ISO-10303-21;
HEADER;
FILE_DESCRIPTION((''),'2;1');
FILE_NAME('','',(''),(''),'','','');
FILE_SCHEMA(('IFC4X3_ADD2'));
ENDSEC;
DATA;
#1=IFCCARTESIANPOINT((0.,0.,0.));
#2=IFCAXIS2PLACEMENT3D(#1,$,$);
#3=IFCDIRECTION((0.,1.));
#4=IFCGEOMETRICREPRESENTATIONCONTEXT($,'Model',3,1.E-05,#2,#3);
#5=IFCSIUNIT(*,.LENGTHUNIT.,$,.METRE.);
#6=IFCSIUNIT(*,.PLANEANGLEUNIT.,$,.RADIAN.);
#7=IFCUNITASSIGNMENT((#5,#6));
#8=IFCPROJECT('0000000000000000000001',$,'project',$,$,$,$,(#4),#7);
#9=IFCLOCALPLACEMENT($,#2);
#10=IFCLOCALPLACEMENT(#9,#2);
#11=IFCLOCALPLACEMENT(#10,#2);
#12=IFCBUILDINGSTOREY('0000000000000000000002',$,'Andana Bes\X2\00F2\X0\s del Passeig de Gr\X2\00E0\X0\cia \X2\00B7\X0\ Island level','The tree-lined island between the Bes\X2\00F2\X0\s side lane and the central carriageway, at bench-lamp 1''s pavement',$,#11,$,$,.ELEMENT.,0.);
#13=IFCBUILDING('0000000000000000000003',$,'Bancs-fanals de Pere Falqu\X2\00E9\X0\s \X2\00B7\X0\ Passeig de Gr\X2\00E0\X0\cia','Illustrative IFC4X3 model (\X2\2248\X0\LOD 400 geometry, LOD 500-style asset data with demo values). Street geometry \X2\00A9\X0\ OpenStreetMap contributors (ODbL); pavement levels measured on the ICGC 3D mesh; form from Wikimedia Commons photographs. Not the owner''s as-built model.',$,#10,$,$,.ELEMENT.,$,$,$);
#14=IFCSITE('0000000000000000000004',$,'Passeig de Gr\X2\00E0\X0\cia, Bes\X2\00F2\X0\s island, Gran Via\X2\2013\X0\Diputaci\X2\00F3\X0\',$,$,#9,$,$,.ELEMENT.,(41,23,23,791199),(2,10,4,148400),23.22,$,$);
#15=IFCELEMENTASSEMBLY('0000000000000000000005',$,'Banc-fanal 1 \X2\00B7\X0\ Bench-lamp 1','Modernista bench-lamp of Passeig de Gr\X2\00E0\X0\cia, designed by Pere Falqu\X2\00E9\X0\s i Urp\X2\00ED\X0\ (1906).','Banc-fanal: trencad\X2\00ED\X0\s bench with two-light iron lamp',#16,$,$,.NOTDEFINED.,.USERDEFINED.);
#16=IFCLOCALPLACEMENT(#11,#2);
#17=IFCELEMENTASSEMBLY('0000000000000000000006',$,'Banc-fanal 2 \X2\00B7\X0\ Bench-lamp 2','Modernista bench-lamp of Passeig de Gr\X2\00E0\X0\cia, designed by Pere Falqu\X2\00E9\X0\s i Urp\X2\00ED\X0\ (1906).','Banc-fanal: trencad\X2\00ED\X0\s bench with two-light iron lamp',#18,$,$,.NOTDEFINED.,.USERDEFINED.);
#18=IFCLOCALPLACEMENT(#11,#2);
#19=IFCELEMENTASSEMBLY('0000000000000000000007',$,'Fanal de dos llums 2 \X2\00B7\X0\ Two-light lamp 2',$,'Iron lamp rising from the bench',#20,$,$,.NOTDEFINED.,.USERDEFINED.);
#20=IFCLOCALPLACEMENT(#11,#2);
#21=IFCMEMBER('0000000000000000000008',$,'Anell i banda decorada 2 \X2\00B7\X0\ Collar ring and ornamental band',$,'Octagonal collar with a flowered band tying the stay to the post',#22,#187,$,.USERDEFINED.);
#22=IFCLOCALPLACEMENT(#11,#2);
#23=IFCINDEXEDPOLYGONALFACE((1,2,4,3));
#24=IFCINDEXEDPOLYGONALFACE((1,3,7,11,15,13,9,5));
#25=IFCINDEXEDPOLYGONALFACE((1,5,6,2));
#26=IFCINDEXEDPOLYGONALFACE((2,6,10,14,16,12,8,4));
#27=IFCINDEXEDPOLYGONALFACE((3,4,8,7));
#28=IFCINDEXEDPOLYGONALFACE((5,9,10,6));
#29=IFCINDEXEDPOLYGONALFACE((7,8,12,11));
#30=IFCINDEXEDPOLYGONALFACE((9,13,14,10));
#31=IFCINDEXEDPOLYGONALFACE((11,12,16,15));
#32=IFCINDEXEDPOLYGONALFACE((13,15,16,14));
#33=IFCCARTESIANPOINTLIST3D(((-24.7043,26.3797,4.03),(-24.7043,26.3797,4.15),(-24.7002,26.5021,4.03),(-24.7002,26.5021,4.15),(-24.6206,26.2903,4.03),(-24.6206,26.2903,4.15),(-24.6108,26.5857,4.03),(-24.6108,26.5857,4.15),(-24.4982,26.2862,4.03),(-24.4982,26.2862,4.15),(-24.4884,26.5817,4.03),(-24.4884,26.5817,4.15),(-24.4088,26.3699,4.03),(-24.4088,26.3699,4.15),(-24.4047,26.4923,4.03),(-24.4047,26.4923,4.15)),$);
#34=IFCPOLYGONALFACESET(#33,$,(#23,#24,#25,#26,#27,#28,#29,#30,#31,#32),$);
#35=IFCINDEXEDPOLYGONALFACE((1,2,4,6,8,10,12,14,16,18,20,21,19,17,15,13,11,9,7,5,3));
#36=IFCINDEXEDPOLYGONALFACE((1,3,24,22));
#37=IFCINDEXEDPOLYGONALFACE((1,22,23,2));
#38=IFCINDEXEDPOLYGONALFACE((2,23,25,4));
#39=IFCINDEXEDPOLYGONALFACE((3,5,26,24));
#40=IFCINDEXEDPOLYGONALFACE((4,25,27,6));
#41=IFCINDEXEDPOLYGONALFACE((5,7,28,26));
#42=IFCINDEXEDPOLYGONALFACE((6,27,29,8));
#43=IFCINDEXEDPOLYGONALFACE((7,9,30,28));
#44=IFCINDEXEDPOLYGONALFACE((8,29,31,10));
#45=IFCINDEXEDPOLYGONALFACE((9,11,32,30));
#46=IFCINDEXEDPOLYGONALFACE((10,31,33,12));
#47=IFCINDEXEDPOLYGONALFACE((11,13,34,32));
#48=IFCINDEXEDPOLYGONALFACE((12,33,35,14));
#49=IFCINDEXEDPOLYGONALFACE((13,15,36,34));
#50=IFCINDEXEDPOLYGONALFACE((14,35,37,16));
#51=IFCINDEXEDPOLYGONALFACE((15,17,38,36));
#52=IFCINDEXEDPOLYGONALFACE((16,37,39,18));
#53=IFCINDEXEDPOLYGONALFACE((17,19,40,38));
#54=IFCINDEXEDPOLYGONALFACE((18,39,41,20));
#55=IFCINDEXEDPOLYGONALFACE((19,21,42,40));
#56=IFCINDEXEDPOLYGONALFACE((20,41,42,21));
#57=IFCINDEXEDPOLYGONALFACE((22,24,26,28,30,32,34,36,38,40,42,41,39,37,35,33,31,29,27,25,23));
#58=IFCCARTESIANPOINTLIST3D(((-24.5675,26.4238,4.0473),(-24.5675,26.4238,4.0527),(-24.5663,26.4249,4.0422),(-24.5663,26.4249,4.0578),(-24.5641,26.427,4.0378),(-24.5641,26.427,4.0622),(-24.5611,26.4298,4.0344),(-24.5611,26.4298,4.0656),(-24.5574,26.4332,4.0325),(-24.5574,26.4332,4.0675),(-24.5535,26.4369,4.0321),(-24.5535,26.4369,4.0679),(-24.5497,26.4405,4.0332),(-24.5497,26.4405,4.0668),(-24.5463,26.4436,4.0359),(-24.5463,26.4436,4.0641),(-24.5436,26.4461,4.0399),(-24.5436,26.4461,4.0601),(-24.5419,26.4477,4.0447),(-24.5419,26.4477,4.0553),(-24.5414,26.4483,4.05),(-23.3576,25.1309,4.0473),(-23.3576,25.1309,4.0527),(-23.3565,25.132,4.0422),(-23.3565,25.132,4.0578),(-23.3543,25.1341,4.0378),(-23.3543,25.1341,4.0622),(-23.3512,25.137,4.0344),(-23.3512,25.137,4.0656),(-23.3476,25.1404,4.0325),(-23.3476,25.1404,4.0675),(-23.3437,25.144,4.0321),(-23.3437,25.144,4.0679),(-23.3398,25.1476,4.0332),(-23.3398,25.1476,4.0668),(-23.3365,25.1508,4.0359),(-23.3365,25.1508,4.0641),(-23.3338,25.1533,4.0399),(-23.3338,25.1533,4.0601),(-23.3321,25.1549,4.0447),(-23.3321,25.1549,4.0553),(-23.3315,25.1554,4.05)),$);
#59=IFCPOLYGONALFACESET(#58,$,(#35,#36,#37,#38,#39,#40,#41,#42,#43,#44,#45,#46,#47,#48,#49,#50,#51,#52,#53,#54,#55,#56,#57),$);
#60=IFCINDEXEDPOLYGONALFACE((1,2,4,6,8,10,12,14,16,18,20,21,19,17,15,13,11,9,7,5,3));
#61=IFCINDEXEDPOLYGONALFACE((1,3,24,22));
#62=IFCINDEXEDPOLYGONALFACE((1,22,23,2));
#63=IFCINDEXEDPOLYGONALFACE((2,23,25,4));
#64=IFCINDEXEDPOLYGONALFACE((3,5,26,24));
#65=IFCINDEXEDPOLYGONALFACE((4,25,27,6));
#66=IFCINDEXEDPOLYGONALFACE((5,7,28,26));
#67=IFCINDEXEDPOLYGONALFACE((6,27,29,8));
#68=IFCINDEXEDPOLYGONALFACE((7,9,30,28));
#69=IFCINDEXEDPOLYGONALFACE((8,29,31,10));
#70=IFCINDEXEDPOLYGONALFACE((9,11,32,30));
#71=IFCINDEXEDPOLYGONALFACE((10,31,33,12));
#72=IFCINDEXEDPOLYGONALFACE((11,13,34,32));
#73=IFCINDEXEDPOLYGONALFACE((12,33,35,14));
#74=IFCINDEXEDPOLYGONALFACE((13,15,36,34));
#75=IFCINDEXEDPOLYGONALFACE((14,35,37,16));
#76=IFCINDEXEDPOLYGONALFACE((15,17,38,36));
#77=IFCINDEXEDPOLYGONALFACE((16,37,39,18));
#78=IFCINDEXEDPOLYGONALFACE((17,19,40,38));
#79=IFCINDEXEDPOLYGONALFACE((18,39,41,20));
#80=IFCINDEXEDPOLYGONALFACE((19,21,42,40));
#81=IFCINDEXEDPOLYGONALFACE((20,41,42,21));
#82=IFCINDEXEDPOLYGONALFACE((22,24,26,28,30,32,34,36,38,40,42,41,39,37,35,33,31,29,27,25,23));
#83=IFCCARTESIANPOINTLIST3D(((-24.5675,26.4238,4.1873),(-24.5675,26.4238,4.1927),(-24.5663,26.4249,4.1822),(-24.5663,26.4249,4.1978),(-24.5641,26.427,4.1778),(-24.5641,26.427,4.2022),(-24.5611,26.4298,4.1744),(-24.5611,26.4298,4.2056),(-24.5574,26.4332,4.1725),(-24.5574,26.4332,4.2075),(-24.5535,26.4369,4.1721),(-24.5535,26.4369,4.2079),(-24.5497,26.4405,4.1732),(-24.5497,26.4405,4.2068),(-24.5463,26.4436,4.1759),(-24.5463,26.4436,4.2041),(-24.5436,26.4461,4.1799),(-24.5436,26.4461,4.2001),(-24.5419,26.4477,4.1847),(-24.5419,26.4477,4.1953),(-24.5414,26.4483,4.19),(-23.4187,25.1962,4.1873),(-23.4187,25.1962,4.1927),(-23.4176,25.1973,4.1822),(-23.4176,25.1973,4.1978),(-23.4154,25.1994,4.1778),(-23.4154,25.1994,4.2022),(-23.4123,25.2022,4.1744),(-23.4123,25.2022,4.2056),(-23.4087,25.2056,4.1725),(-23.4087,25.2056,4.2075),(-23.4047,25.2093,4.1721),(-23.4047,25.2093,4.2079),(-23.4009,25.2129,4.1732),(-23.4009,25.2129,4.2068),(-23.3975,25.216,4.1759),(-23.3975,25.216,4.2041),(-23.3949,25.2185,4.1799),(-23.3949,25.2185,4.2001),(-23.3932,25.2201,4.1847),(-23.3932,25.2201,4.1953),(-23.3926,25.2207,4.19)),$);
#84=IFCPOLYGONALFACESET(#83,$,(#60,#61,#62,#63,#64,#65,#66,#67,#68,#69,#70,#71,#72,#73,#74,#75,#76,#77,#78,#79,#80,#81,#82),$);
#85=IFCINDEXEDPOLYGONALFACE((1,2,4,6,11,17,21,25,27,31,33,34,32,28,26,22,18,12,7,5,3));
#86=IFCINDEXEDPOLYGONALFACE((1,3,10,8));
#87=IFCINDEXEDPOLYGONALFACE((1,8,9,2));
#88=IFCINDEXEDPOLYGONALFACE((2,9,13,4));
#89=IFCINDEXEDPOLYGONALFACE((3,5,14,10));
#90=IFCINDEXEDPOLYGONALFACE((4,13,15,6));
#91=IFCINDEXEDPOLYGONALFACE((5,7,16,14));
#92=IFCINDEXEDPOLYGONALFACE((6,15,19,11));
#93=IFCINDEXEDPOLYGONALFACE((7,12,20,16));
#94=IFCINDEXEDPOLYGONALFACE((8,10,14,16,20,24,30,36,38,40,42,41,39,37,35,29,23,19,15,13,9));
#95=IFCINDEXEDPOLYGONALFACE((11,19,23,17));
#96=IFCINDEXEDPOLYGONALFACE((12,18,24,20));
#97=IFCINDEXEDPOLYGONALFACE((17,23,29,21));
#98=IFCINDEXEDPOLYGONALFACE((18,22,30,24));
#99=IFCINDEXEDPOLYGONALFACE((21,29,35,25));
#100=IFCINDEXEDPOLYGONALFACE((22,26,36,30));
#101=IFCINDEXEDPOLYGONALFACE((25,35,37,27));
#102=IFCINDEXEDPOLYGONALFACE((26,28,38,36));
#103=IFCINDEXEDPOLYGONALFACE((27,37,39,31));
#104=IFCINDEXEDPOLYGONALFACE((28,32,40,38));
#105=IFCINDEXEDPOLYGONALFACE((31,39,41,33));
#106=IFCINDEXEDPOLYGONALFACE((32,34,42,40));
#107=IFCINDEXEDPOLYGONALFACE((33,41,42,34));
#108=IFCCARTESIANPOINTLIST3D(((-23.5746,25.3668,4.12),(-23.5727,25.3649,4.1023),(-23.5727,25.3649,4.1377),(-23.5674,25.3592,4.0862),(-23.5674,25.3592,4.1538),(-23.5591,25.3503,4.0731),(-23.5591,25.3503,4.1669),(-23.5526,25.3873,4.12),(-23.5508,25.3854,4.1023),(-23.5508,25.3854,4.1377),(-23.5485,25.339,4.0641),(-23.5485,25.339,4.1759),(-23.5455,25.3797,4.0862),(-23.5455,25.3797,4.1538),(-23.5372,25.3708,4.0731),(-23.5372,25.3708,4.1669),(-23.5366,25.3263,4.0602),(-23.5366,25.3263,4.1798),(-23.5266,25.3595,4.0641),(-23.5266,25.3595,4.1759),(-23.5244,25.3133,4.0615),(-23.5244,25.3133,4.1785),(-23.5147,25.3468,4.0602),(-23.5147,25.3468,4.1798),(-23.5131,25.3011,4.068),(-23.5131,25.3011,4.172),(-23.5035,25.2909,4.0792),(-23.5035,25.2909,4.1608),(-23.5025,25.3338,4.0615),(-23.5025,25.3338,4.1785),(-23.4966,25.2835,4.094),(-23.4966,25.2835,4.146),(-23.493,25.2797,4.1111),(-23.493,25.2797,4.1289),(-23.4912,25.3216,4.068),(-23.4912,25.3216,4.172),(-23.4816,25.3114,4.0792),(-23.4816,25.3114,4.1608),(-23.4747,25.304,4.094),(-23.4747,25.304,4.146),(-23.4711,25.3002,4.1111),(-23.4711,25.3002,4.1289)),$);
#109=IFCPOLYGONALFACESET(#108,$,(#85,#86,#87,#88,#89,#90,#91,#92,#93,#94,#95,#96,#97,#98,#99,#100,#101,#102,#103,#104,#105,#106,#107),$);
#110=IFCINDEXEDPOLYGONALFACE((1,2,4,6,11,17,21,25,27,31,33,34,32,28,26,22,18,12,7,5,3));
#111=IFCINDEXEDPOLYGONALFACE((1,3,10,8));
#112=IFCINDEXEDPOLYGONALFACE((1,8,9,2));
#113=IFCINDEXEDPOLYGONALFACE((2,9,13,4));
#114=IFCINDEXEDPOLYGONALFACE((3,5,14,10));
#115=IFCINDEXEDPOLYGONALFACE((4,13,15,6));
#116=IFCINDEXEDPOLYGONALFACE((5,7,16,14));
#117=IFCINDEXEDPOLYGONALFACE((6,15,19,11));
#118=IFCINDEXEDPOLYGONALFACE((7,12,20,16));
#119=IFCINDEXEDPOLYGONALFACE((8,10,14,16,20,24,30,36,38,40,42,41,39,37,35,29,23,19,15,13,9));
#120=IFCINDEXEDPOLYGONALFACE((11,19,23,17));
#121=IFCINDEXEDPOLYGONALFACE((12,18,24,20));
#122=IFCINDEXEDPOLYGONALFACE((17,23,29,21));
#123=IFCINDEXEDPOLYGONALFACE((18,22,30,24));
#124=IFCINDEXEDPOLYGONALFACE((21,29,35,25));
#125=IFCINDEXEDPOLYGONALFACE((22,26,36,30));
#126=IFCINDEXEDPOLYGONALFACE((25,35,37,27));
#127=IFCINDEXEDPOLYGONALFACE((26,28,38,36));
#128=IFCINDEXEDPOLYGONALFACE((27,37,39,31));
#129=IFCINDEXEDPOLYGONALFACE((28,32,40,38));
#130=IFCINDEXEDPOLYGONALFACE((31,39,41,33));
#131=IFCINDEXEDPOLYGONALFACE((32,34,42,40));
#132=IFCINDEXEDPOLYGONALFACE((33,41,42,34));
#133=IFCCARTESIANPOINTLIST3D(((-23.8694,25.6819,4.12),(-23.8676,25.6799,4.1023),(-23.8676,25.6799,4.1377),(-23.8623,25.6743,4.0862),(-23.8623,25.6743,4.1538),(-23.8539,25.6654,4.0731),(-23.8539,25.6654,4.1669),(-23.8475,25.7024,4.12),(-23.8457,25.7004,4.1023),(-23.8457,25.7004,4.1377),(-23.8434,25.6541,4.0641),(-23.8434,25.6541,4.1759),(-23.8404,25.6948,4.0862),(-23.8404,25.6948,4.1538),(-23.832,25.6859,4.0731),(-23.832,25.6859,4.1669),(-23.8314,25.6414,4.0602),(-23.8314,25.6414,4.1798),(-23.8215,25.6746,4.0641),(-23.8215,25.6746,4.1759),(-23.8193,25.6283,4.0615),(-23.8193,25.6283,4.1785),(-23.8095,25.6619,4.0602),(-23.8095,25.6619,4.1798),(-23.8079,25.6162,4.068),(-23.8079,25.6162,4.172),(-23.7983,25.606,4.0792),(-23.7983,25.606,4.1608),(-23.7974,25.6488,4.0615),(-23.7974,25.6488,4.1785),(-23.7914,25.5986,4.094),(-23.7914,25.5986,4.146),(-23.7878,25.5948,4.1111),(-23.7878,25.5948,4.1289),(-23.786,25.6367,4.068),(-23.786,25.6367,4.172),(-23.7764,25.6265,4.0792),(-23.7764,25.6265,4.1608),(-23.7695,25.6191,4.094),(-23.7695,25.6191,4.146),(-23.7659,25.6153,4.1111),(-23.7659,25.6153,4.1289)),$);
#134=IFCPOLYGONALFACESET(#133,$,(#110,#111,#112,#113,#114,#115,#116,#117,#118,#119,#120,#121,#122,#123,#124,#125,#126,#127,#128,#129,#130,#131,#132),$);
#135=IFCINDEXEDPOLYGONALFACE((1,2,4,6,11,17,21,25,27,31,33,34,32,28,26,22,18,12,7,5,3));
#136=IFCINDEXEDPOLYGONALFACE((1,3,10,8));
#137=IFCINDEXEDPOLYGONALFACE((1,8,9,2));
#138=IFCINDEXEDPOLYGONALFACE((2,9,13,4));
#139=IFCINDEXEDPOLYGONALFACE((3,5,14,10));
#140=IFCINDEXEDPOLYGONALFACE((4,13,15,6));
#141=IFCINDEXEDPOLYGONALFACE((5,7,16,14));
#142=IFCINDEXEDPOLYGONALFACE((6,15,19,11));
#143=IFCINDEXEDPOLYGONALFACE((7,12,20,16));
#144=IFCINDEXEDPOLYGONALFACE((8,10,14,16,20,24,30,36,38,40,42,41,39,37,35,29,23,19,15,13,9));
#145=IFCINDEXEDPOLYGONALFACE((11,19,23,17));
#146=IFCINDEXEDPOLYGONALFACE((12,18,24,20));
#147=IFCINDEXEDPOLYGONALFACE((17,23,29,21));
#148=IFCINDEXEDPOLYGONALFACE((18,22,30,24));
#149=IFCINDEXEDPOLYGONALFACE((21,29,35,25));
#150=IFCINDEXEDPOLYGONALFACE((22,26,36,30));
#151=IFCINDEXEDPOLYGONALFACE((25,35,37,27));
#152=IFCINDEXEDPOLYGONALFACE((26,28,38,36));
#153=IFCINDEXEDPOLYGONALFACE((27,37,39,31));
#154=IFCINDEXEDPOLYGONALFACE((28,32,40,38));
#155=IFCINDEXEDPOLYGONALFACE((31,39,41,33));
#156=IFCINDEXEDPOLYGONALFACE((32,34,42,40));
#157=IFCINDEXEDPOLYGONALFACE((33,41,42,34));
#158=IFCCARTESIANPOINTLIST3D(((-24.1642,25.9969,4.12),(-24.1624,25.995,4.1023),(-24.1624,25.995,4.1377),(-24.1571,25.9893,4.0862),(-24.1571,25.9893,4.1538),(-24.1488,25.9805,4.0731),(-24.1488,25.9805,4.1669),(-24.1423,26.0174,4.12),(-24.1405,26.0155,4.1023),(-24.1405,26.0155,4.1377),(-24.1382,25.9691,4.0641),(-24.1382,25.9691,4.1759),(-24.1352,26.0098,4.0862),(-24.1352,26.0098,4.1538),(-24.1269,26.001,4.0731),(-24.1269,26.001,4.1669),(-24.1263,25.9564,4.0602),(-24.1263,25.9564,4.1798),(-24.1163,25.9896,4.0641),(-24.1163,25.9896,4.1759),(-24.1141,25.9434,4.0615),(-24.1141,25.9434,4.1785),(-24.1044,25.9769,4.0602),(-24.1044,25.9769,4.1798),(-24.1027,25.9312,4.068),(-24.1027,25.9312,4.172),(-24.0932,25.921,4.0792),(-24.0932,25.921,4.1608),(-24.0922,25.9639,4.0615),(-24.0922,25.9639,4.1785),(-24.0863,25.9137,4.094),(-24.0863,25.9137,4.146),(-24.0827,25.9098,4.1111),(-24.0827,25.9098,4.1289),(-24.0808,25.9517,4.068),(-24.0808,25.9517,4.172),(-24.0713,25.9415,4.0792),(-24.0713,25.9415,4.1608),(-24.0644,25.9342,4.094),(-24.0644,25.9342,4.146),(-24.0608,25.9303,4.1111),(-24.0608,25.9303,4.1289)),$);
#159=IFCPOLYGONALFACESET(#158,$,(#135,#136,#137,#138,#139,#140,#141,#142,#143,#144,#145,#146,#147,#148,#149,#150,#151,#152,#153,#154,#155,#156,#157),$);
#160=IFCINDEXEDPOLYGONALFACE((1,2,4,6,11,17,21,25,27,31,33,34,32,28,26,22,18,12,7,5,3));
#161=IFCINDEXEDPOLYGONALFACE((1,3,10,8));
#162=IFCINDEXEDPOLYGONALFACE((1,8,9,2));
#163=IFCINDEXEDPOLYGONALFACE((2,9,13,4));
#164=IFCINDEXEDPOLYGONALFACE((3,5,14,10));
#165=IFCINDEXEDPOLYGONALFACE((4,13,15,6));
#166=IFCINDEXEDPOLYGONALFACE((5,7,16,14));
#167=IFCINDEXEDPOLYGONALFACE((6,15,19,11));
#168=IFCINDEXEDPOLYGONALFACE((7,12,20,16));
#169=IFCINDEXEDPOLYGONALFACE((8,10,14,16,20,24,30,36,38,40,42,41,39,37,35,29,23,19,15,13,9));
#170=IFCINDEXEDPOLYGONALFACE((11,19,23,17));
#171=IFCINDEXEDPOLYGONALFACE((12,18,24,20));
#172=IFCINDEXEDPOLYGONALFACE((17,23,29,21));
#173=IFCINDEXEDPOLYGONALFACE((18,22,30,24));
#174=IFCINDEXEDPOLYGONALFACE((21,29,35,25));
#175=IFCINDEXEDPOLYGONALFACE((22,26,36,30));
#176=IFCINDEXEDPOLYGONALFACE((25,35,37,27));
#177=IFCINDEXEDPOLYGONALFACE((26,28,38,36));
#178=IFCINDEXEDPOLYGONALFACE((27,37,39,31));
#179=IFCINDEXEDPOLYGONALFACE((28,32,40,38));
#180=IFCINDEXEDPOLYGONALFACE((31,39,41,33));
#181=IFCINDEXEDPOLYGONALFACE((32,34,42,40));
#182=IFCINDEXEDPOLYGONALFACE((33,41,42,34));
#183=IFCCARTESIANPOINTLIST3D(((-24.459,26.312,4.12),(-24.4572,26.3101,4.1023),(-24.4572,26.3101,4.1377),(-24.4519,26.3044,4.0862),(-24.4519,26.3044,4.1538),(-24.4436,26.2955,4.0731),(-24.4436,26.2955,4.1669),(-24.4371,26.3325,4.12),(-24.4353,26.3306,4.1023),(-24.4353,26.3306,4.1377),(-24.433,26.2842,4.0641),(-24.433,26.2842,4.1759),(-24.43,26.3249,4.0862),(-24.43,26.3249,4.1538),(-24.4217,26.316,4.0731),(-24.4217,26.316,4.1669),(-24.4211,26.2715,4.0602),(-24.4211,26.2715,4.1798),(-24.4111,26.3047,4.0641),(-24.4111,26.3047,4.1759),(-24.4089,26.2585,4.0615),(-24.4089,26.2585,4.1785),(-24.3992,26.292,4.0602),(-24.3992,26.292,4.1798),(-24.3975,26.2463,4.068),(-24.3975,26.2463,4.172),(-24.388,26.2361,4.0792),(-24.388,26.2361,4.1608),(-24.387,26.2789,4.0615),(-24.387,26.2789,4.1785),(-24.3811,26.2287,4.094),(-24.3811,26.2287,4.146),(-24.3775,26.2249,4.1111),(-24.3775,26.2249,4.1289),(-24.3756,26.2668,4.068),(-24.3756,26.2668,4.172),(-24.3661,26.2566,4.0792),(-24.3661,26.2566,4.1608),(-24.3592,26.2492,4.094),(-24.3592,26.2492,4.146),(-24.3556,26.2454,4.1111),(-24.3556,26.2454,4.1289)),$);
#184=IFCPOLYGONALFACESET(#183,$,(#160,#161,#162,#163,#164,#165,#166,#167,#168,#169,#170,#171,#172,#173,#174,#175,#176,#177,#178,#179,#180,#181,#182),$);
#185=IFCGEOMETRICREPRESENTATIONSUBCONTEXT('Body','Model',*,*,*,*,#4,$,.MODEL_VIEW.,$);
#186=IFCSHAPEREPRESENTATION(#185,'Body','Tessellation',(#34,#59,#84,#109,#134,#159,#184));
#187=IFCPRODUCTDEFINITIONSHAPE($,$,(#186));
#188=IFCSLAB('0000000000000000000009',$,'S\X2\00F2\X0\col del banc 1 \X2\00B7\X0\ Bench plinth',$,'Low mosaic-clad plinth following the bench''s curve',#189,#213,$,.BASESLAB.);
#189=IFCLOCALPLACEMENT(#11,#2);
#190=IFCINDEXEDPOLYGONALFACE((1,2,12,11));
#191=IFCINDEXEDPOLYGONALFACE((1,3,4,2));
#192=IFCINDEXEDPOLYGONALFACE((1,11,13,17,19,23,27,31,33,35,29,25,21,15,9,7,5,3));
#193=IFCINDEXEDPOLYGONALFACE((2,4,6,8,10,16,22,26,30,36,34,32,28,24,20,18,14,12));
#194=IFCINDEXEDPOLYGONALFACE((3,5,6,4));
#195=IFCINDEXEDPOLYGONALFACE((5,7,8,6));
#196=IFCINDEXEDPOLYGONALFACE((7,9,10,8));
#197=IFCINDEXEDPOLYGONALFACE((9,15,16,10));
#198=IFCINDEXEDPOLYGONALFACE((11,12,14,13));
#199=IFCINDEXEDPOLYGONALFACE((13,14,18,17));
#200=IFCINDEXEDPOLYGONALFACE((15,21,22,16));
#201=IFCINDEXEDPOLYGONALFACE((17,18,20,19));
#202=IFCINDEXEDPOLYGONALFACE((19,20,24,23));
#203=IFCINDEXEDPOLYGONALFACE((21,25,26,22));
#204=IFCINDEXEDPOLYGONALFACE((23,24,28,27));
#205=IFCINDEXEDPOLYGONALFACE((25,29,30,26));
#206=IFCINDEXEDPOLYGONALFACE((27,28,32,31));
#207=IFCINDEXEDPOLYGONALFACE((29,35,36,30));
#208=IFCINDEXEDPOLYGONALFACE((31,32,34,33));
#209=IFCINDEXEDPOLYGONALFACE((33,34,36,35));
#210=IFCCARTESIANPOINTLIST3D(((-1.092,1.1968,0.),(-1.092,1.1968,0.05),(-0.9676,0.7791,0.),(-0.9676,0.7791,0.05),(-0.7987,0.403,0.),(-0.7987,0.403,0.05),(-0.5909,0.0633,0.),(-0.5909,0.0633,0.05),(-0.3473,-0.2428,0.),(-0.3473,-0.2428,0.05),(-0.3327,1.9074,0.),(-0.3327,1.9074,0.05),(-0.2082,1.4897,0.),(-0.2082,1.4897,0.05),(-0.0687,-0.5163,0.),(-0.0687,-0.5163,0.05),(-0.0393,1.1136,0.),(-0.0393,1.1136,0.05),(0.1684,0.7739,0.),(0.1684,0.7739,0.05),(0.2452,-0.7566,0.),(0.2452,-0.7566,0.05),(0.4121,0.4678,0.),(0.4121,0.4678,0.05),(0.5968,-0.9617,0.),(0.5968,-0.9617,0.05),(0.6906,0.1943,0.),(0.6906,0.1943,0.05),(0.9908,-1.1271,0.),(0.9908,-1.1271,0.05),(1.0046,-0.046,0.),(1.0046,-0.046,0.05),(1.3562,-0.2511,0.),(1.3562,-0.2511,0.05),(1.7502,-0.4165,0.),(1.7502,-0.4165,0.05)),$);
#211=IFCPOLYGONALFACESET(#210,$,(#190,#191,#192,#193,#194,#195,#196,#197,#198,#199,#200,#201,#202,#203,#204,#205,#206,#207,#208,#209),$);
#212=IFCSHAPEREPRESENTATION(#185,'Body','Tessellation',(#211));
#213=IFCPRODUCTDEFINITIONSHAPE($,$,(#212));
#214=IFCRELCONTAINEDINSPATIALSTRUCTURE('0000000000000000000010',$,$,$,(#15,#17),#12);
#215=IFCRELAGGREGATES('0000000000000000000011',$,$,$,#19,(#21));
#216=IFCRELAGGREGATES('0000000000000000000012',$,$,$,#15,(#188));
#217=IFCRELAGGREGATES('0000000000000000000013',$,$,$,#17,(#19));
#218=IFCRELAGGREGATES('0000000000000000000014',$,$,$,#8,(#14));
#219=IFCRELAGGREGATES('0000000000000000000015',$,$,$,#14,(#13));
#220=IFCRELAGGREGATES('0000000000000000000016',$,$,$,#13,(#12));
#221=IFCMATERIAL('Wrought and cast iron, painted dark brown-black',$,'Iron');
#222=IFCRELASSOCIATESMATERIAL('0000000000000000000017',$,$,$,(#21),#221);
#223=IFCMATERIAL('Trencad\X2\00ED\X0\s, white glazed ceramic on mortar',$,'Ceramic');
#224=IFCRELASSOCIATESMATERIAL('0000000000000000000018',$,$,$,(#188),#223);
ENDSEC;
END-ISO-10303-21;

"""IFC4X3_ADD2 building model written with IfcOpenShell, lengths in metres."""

from ifc_helpers import new_model, si_unit, direction, frame, origin, origin_2d_with_axis, place, context, subcontext, project, spatial, polyline, circle, outline, extrude, material, element, aggregate, save


model = new_model("IFC4X3_ADD2")

# Units and contexts
model_context = context("Model", 3, precision=1e-05, world=origin(), true_north=direction((0.0, 1.0)))
body_context = subcontext(model_context, "Body", "Model", "MODEL_VIEW")
ifc_project = project(units=[si_unit("LENGTHUNIT", "METRE"), si_unit("PLANEANGLEUNIT", "RADIAN")], contexts=[model_context])

# Site, building, storey
site_placement = place(None, origin())
site = spatial("IfcSite", under=ifc_project, at=site_placement, Name="Passeig de Gràcia, Besòs island, Gran Via–Diputació", CompositionType="ELEMENT", RefLatitude=(41, 23, 23, 791199), RefLongitude=(2, 10, 4, 148400), RefElevation=23.22)
building_placement = place(site_placement, origin())
building = spatial("IfcBuilding", under=site, at=building_placement, Name="Bancs-fanals de Pere Falqués · Passeig de Gràcia", Description="Illustrative IFC4X3 model (≈LOD 400 geometry, LOD 500-style asset data with demo values). Street geometry © OpenStreetMap contributors (ODbL); pavement levels measured on the ICGC 3D mesh; form from Wikimedia Commons photographs. Not the owner's as-built model.", CompositionType="ELEMENT")
storey_placement = place(building_placement, origin())
storey = spatial("IfcBuildingStorey", under=building, at=storey_placement, Name="Andana Besòs del Passeig de Gràcia · Island level", Description="The tree-lined island between the Besòs side lane and the central carriageway, at bench-lamp 1's pavement", CompositionType="ELEMENT", Elevation=0.0)

# Element assemblies
assembly_1_placement = place(building_placement, origin())
assembly_1 = element("IfcElementAssembly", 1, at=assembly_1_placement, inside=storey, Name="Banc-fanal 1 · Bench-lamp 1", Description="Modernista bench-lamp of Passeig de Gràcia, designed by Pere Falqués i Urpí (1906).", ObjectType="Banc-fanal: trencadís bench with two-light iron lamp", AssemblyPlace="NOTDEFINED", PredefinedType="USERDEFINED")
assembly_2_placement = place(building_placement, origin())
assembly_2 = element("IfcElementAssembly", 2, at=assembly_2_placement, inside=storey, Name="Banc-fanal 2 · Bench-lamp 2", Description="Modernista bench-lamp of Passeig de Gràcia, designed by Pere Falqués i Urpí (1906).", ObjectType="Banc-fanal: trencadís bench with two-light iron lamp", AssemblyPlace="NOTDEFINED", PredefinedType="USERDEFINED")

# Element assembly
ifc_material_1 = material(Name="Wrought and cast iron, painted dark brown-black", Category="Iron")
assembly_3_placement = place(building_placement, origin())
assembly_3 = element("IfcElementAssembly", 3, at=assembly_3_placement, Name="Fanal de dos llums 2 · Two-light lamp 2", ObjectType="Iron lamp rising from the bench", AssemblyPlace="NOTDEFINED", PredefinedType="USERDEFINED")

# Member
member_1_placement = place(building_placement, origin())
member_1 = element("IfcMember", 4, at=member_1_placement, material=ifc_material_1, Name="Anell i banda decorada 2 · Collar ring and ornamental band", ObjectType="Octagonal collar with a flowered band tying the stay to the post", PredefinedType="USERDEFINED", context=body_context, shape_type="SweptSolid", body=[
    extrude(outline(polyline([(-24.7002, 26.5021), (-24.7043, 26.3797), (-24.6206, 26.2903), (-24.4982, 26.2862), (-24.4088, 26.3699), (-24.4047, 26.4923), (-24.4884, 26.5817), (-24.6108, 26.5857), (-24.7002, 26.5021)])), frame((0.0, 0.0, 4.03)), (0.0, 0.0, 1.0), 0.12),
    extrude(circle(Radius=0.018, at=origin_2d_with_axis()), frame((-23.3446, 25.1431, 4.05), z_axis=(-0.683274, 0.730162, 0.0), x_axis=(0.730162, 0.683274, 0.0)), (0.0, 0.0, 1.0), 1.7707),
    extrude(circle(Radius=0.018, at=origin_2d_with_axis()), frame((-23.4057, 25.2084, 4.19), z_axis=(-0.683274, 0.730162, 0.0), x_axis=(0.730162, 0.683274, 0.0)), (0.0, 0.0, 1.0), 1.6813),
    extrude(circle(Radius=0.06, at=origin_2d_with_axis()), frame((-23.5116, 25.3435, 4.12), z_axis=(-0.730162, -0.683274, 0.0), x_axis=(-0.683274, 0.730162, 0.0)), (0.0, 0.0, 1.0), 0.03),
    extrude(circle(Radius=0.06, at=origin_2d_with_axis()), frame((-23.8065, 25.6586, 4.12), z_axis=(-0.730162, -0.683274, 0.0), x_axis=(-0.683274, 0.730162, 0.0)), (0.0, 0.0, 1.0), 0.03),
    extrude(circle(Radius=0.06, at=origin_2d_with_axis()), frame((-24.1013, 25.9736, 4.12), z_axis=(-0.730162, -0.683274, 0.0), x_axis=(-0.683274, 0.730162, 0.0)), (0.0, 0.0, 1.0), 0.03),
    extrude(circle(Radius=0.06, at=origin_2d_with_axis()), frame((-24.3961, 26.2887, 4.12), z_axis=(-0.730162, -0.683274, 0.0), x_axis=(-0.683274, 0.730162, 0.0)), (0.0, 0.0, 1.0), 0.03),
])
aggregate(assembly_3, [member_1])

# Slab
ifc_material_2 = material(Name="Trencadís, white glazed ceramic on mortar", Category="Ceramic")
slab_1_placement = place(building_placement, origin())
slab_1 = element("IfcSlab", 5, at=slab_1_placement, material=ifc_material_2, Name="Sòcol del banc 1 · Bench plinth", ObjectType="Low mosaic-clad plinth following the bench's curve", PredefinedType="BASESLAB", context=body_context, shape_type="SweptSolid", body=[
    extrude(outline(polyline([(1.7502, -0.4165), (1.3562, -0.2511), (1.0046, -0.046), (0.6906, 0.1943), (0.4121, 0.4678), (0.1684, 0.7739), (-0.0393, 1.1136), (-0.2082, 1.4897), (-0.3327, 1.9074), (-1.092, 1.1968), (-0.9676, 0.7791), (-0.7987, 0.403), (-0.5909, 0.0633), (-0.3473, -0.2428), (-0.0687, -0.5163), (0.2452, -0.7566), (0.5968, -0.9617), (0.9908, -1.1271), (1.7502, -0.4165)])), origin(), (0.0, 0.0, 1.0), 0.05),
])

aggregate(assembly_1, [slab_1])
aggregate(assembly_2, [assembly_3])

save(model, "model.ifc")
